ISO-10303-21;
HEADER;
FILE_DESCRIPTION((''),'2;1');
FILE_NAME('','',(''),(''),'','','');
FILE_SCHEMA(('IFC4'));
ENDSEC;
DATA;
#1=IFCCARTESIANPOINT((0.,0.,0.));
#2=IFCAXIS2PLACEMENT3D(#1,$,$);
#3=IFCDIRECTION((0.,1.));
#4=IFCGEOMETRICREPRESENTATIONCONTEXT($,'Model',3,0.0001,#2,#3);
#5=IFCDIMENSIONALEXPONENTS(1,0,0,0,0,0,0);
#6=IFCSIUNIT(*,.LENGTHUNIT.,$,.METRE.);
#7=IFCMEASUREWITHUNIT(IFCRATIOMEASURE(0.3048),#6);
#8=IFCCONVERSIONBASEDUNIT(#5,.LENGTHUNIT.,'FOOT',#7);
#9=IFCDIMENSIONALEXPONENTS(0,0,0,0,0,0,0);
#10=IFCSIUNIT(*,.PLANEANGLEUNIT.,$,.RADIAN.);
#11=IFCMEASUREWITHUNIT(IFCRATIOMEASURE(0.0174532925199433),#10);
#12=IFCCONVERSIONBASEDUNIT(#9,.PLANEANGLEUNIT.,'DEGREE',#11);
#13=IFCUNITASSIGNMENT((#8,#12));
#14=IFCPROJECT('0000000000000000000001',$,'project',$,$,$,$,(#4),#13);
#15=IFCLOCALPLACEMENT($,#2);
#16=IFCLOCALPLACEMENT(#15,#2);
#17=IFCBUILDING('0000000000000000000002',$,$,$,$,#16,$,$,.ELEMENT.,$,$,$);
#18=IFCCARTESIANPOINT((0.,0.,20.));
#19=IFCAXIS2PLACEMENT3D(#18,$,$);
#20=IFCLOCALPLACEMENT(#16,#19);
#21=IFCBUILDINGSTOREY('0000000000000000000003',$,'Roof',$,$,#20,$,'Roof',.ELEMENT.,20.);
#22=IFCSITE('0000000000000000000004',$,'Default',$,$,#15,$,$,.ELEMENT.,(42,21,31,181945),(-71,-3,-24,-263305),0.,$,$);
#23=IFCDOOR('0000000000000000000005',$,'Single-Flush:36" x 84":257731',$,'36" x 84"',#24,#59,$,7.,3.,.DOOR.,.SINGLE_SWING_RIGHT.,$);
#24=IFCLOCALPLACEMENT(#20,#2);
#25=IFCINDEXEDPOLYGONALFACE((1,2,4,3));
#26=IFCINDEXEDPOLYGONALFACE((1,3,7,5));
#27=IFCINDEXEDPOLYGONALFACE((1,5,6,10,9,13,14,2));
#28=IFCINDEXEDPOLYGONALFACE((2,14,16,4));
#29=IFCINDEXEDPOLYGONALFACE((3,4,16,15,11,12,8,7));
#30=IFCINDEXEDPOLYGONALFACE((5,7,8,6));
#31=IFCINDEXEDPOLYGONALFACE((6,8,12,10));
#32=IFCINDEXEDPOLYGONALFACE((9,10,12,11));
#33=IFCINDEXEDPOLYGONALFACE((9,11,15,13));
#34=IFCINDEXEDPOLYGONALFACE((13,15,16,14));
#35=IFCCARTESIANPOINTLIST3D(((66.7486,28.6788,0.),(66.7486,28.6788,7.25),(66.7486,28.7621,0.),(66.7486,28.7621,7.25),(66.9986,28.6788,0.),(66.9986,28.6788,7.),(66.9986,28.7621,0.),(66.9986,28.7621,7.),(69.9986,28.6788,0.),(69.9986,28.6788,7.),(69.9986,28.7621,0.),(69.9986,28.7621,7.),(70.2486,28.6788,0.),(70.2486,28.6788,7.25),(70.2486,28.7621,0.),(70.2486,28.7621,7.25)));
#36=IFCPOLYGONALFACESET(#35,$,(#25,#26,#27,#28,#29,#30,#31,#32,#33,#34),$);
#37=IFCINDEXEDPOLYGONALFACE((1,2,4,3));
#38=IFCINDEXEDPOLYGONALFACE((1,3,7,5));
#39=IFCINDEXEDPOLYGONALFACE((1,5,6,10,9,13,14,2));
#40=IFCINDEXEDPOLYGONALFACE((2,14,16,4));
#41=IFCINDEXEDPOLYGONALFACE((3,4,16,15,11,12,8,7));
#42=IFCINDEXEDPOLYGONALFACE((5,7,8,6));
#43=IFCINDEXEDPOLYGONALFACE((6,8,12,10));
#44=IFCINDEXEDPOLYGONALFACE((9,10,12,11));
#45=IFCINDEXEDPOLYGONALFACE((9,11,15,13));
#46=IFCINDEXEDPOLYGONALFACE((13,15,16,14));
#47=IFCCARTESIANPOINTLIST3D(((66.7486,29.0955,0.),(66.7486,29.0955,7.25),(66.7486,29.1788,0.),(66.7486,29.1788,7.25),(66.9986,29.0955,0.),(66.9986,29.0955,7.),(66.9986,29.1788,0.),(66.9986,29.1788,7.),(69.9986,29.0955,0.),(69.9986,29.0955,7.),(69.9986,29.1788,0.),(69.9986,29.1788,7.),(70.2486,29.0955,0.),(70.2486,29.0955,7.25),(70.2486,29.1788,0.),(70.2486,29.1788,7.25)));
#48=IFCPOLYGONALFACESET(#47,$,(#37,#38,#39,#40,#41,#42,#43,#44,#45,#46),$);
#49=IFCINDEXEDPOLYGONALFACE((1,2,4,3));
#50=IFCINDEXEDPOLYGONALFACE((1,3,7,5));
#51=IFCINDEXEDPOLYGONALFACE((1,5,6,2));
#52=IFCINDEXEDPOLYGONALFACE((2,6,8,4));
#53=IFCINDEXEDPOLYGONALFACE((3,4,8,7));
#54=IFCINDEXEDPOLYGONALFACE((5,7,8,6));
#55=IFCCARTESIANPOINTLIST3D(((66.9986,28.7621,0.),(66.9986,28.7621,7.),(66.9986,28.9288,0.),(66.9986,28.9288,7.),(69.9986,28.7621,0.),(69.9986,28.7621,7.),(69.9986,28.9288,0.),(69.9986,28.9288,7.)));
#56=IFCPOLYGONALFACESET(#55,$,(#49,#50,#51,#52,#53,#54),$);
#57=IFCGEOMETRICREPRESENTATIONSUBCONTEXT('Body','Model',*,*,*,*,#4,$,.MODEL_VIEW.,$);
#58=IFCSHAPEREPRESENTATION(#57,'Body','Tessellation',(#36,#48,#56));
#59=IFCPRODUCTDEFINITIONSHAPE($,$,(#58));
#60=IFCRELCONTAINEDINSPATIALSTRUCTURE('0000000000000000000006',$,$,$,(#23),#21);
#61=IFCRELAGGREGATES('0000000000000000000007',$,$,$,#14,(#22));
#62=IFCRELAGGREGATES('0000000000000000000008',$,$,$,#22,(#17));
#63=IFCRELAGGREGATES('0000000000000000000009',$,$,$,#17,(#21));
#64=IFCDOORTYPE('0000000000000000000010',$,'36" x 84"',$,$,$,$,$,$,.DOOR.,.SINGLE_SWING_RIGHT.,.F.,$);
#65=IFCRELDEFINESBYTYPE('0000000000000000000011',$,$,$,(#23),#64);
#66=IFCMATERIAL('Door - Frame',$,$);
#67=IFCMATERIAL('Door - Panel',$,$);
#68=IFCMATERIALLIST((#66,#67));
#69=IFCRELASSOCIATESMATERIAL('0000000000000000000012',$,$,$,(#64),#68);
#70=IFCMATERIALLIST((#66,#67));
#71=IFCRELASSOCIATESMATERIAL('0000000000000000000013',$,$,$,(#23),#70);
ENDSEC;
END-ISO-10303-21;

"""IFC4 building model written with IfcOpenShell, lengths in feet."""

from ifc_helpers import new_model, entity, si_unit, converted_unit, direction, frame, frame_2d, origin, place, context, subcontext, project, spatial, polyline, rectangle, outline, extrude, source, transform, mapped, material, material_list, type_object, type_shapes, element, save


model = new_model("IFC4")

# Units and contexts
model_context = context("Model", 3, precision=0.0001, world=origin(), true_north=direction((0.0, 1.0)))
body_context = subcontext(model_context, "Body", "Model", "MODEL_VIEW")
ifc_project = project(units=[converted_unit("LENGTHUNIT", "FOOT", entity("IfcRatioMeasure", 0.3048), si_unit("LENGTHUNIT", "METRE"), dimensions=[1, 0, 0, 0, 0, 0, 0]), converted_unit("PLANEANGLEUNIT", "DEGREE", entity("IfcRatioMeasure", 0.0174532925199433), si_unit("PLANEANGLEUNIT", "RADIAN"), dimensions=[0, 0, 0, 0, 0, 0, 0])], contexts=[model_context])

# Site, building, storey
site_placement = place(None, origin())
site = spatial("IfcSite", under=ifc_project, at=site_placement, Name="Default", CompositionType="ELEMENT", RefLatitude=(42, 21, 31, 181945), RefLongitude=(-71, -3, -24, -263305), RefElevation=0.0)
building_placement = place(site_placement, origin())
building = spatial("IfcBuilding", under=site, at=building_placement, CompositionType="ELEMENT")
storey_placement = place(building_placement, frame((0.0, 0.0, 20.0)))
storey = spatial("IfcBuildingStorey", under=building, at=storey_placement, Name="Roof", LongName="Roof", CompositionType="ELEMENT", Elevation=20.0)

# Shared definitions
placement_1 = place(storey_placement, frame((-0.1681, 28.9288, 0.0)))

# Door
ifc_material_1 = material(Name="Door - Frame")
ifc_material_2 = material(Name="Door - Panel")
ifc_material_list_1 = material_list([ifc_material_1, ifc_material_2])
ifc_material_list_2 = material_list([ifc_material_1, ifc_material_2])
door_type = type_object("IfcDoorType", Name="36\" x 84\"", OperationType="SINGLE_SWING_RIGHT", ParameterTakesPrecedence=False, PredefinedType="DOOR", material=ifc_material_list_2)
shared_shape = source(origin(), body_context, "Body", "SweptSolid", [
    extrude(outline(polyline([(-1.75, -3.6875), (1.75, -3.6875), (1.75, 3.5625), (1.5, 3.5625), (1.5, -3.4375), (-1.5, -3.4375), (-1.5, 3.5625), (-1.75, 3.5625), (-1.75, -3.6875)])), frame((1.5, 0.3333, 3.5625), z_axis=(0.0, 1.0, 0.0), x_axis=(1.0, 0.0, 0.0)), (0.0, 0.0, 1.0), 0.0833),
    extrude(outline(polyline([(-3.6875, -1.75), (3.5625, -1.75), (3.5625, -1.5), (-3.4375, -1.5), (-3.4375, 1.5), (3.5625, 1.5), (3.5625, 1.75), (-3.6875, 1.75), (-3.6875, -1.75)])), frame((1.5, -0.0833, 3.5625), z_axis=(0.0, 1.0, 0.0), x_axis=(0.0, 0.0, -1.0)), (0.0, 0.0, 1.0), 0.0833),
    extrude(rectangle(XDim=0.1667, YDim=3.0, at=frame_2d((0.0, 0.0), x_axis=(1.0, 0.0))), frame((1.5, 0.25, 0.0), z_axis=(0.0, 0.0, 1.0), x_axis=(0.0, 1.0, 0.0)), (0.0, 0.0, 1.0), 7.0),
])
type_shapes(door_type, [shared_shape])
placement_2 = place(placement_1, frame((70.1667, 0.1667, 0.0)))
door_placement = place(placement_2, frame((0.0, 0.0, 0.0), z_axis=(0.0, 0.0, 1.0), x_axis=(-1.0, 0.0, 0.0)))
element("IfcDoor", 1, at=door_placement, inside=storey, type_object=door_type, material=ifc_material_list_1, Name="Single-Flush:36\" x 84\":257731", ObjectType="36\" x 84\"", OperationType="SINGLE_SWING_RIGHT", OverallHeight=7.0, OverallWidth=3.0, PredefinedType="DOOR", context=body_context, shape_type="MappedRepresentation", body=[
    mapped(shared_shape, transform((0.0, 0.0, 0.0), scale=1.0)),
])

save(model, "model.ifc")
